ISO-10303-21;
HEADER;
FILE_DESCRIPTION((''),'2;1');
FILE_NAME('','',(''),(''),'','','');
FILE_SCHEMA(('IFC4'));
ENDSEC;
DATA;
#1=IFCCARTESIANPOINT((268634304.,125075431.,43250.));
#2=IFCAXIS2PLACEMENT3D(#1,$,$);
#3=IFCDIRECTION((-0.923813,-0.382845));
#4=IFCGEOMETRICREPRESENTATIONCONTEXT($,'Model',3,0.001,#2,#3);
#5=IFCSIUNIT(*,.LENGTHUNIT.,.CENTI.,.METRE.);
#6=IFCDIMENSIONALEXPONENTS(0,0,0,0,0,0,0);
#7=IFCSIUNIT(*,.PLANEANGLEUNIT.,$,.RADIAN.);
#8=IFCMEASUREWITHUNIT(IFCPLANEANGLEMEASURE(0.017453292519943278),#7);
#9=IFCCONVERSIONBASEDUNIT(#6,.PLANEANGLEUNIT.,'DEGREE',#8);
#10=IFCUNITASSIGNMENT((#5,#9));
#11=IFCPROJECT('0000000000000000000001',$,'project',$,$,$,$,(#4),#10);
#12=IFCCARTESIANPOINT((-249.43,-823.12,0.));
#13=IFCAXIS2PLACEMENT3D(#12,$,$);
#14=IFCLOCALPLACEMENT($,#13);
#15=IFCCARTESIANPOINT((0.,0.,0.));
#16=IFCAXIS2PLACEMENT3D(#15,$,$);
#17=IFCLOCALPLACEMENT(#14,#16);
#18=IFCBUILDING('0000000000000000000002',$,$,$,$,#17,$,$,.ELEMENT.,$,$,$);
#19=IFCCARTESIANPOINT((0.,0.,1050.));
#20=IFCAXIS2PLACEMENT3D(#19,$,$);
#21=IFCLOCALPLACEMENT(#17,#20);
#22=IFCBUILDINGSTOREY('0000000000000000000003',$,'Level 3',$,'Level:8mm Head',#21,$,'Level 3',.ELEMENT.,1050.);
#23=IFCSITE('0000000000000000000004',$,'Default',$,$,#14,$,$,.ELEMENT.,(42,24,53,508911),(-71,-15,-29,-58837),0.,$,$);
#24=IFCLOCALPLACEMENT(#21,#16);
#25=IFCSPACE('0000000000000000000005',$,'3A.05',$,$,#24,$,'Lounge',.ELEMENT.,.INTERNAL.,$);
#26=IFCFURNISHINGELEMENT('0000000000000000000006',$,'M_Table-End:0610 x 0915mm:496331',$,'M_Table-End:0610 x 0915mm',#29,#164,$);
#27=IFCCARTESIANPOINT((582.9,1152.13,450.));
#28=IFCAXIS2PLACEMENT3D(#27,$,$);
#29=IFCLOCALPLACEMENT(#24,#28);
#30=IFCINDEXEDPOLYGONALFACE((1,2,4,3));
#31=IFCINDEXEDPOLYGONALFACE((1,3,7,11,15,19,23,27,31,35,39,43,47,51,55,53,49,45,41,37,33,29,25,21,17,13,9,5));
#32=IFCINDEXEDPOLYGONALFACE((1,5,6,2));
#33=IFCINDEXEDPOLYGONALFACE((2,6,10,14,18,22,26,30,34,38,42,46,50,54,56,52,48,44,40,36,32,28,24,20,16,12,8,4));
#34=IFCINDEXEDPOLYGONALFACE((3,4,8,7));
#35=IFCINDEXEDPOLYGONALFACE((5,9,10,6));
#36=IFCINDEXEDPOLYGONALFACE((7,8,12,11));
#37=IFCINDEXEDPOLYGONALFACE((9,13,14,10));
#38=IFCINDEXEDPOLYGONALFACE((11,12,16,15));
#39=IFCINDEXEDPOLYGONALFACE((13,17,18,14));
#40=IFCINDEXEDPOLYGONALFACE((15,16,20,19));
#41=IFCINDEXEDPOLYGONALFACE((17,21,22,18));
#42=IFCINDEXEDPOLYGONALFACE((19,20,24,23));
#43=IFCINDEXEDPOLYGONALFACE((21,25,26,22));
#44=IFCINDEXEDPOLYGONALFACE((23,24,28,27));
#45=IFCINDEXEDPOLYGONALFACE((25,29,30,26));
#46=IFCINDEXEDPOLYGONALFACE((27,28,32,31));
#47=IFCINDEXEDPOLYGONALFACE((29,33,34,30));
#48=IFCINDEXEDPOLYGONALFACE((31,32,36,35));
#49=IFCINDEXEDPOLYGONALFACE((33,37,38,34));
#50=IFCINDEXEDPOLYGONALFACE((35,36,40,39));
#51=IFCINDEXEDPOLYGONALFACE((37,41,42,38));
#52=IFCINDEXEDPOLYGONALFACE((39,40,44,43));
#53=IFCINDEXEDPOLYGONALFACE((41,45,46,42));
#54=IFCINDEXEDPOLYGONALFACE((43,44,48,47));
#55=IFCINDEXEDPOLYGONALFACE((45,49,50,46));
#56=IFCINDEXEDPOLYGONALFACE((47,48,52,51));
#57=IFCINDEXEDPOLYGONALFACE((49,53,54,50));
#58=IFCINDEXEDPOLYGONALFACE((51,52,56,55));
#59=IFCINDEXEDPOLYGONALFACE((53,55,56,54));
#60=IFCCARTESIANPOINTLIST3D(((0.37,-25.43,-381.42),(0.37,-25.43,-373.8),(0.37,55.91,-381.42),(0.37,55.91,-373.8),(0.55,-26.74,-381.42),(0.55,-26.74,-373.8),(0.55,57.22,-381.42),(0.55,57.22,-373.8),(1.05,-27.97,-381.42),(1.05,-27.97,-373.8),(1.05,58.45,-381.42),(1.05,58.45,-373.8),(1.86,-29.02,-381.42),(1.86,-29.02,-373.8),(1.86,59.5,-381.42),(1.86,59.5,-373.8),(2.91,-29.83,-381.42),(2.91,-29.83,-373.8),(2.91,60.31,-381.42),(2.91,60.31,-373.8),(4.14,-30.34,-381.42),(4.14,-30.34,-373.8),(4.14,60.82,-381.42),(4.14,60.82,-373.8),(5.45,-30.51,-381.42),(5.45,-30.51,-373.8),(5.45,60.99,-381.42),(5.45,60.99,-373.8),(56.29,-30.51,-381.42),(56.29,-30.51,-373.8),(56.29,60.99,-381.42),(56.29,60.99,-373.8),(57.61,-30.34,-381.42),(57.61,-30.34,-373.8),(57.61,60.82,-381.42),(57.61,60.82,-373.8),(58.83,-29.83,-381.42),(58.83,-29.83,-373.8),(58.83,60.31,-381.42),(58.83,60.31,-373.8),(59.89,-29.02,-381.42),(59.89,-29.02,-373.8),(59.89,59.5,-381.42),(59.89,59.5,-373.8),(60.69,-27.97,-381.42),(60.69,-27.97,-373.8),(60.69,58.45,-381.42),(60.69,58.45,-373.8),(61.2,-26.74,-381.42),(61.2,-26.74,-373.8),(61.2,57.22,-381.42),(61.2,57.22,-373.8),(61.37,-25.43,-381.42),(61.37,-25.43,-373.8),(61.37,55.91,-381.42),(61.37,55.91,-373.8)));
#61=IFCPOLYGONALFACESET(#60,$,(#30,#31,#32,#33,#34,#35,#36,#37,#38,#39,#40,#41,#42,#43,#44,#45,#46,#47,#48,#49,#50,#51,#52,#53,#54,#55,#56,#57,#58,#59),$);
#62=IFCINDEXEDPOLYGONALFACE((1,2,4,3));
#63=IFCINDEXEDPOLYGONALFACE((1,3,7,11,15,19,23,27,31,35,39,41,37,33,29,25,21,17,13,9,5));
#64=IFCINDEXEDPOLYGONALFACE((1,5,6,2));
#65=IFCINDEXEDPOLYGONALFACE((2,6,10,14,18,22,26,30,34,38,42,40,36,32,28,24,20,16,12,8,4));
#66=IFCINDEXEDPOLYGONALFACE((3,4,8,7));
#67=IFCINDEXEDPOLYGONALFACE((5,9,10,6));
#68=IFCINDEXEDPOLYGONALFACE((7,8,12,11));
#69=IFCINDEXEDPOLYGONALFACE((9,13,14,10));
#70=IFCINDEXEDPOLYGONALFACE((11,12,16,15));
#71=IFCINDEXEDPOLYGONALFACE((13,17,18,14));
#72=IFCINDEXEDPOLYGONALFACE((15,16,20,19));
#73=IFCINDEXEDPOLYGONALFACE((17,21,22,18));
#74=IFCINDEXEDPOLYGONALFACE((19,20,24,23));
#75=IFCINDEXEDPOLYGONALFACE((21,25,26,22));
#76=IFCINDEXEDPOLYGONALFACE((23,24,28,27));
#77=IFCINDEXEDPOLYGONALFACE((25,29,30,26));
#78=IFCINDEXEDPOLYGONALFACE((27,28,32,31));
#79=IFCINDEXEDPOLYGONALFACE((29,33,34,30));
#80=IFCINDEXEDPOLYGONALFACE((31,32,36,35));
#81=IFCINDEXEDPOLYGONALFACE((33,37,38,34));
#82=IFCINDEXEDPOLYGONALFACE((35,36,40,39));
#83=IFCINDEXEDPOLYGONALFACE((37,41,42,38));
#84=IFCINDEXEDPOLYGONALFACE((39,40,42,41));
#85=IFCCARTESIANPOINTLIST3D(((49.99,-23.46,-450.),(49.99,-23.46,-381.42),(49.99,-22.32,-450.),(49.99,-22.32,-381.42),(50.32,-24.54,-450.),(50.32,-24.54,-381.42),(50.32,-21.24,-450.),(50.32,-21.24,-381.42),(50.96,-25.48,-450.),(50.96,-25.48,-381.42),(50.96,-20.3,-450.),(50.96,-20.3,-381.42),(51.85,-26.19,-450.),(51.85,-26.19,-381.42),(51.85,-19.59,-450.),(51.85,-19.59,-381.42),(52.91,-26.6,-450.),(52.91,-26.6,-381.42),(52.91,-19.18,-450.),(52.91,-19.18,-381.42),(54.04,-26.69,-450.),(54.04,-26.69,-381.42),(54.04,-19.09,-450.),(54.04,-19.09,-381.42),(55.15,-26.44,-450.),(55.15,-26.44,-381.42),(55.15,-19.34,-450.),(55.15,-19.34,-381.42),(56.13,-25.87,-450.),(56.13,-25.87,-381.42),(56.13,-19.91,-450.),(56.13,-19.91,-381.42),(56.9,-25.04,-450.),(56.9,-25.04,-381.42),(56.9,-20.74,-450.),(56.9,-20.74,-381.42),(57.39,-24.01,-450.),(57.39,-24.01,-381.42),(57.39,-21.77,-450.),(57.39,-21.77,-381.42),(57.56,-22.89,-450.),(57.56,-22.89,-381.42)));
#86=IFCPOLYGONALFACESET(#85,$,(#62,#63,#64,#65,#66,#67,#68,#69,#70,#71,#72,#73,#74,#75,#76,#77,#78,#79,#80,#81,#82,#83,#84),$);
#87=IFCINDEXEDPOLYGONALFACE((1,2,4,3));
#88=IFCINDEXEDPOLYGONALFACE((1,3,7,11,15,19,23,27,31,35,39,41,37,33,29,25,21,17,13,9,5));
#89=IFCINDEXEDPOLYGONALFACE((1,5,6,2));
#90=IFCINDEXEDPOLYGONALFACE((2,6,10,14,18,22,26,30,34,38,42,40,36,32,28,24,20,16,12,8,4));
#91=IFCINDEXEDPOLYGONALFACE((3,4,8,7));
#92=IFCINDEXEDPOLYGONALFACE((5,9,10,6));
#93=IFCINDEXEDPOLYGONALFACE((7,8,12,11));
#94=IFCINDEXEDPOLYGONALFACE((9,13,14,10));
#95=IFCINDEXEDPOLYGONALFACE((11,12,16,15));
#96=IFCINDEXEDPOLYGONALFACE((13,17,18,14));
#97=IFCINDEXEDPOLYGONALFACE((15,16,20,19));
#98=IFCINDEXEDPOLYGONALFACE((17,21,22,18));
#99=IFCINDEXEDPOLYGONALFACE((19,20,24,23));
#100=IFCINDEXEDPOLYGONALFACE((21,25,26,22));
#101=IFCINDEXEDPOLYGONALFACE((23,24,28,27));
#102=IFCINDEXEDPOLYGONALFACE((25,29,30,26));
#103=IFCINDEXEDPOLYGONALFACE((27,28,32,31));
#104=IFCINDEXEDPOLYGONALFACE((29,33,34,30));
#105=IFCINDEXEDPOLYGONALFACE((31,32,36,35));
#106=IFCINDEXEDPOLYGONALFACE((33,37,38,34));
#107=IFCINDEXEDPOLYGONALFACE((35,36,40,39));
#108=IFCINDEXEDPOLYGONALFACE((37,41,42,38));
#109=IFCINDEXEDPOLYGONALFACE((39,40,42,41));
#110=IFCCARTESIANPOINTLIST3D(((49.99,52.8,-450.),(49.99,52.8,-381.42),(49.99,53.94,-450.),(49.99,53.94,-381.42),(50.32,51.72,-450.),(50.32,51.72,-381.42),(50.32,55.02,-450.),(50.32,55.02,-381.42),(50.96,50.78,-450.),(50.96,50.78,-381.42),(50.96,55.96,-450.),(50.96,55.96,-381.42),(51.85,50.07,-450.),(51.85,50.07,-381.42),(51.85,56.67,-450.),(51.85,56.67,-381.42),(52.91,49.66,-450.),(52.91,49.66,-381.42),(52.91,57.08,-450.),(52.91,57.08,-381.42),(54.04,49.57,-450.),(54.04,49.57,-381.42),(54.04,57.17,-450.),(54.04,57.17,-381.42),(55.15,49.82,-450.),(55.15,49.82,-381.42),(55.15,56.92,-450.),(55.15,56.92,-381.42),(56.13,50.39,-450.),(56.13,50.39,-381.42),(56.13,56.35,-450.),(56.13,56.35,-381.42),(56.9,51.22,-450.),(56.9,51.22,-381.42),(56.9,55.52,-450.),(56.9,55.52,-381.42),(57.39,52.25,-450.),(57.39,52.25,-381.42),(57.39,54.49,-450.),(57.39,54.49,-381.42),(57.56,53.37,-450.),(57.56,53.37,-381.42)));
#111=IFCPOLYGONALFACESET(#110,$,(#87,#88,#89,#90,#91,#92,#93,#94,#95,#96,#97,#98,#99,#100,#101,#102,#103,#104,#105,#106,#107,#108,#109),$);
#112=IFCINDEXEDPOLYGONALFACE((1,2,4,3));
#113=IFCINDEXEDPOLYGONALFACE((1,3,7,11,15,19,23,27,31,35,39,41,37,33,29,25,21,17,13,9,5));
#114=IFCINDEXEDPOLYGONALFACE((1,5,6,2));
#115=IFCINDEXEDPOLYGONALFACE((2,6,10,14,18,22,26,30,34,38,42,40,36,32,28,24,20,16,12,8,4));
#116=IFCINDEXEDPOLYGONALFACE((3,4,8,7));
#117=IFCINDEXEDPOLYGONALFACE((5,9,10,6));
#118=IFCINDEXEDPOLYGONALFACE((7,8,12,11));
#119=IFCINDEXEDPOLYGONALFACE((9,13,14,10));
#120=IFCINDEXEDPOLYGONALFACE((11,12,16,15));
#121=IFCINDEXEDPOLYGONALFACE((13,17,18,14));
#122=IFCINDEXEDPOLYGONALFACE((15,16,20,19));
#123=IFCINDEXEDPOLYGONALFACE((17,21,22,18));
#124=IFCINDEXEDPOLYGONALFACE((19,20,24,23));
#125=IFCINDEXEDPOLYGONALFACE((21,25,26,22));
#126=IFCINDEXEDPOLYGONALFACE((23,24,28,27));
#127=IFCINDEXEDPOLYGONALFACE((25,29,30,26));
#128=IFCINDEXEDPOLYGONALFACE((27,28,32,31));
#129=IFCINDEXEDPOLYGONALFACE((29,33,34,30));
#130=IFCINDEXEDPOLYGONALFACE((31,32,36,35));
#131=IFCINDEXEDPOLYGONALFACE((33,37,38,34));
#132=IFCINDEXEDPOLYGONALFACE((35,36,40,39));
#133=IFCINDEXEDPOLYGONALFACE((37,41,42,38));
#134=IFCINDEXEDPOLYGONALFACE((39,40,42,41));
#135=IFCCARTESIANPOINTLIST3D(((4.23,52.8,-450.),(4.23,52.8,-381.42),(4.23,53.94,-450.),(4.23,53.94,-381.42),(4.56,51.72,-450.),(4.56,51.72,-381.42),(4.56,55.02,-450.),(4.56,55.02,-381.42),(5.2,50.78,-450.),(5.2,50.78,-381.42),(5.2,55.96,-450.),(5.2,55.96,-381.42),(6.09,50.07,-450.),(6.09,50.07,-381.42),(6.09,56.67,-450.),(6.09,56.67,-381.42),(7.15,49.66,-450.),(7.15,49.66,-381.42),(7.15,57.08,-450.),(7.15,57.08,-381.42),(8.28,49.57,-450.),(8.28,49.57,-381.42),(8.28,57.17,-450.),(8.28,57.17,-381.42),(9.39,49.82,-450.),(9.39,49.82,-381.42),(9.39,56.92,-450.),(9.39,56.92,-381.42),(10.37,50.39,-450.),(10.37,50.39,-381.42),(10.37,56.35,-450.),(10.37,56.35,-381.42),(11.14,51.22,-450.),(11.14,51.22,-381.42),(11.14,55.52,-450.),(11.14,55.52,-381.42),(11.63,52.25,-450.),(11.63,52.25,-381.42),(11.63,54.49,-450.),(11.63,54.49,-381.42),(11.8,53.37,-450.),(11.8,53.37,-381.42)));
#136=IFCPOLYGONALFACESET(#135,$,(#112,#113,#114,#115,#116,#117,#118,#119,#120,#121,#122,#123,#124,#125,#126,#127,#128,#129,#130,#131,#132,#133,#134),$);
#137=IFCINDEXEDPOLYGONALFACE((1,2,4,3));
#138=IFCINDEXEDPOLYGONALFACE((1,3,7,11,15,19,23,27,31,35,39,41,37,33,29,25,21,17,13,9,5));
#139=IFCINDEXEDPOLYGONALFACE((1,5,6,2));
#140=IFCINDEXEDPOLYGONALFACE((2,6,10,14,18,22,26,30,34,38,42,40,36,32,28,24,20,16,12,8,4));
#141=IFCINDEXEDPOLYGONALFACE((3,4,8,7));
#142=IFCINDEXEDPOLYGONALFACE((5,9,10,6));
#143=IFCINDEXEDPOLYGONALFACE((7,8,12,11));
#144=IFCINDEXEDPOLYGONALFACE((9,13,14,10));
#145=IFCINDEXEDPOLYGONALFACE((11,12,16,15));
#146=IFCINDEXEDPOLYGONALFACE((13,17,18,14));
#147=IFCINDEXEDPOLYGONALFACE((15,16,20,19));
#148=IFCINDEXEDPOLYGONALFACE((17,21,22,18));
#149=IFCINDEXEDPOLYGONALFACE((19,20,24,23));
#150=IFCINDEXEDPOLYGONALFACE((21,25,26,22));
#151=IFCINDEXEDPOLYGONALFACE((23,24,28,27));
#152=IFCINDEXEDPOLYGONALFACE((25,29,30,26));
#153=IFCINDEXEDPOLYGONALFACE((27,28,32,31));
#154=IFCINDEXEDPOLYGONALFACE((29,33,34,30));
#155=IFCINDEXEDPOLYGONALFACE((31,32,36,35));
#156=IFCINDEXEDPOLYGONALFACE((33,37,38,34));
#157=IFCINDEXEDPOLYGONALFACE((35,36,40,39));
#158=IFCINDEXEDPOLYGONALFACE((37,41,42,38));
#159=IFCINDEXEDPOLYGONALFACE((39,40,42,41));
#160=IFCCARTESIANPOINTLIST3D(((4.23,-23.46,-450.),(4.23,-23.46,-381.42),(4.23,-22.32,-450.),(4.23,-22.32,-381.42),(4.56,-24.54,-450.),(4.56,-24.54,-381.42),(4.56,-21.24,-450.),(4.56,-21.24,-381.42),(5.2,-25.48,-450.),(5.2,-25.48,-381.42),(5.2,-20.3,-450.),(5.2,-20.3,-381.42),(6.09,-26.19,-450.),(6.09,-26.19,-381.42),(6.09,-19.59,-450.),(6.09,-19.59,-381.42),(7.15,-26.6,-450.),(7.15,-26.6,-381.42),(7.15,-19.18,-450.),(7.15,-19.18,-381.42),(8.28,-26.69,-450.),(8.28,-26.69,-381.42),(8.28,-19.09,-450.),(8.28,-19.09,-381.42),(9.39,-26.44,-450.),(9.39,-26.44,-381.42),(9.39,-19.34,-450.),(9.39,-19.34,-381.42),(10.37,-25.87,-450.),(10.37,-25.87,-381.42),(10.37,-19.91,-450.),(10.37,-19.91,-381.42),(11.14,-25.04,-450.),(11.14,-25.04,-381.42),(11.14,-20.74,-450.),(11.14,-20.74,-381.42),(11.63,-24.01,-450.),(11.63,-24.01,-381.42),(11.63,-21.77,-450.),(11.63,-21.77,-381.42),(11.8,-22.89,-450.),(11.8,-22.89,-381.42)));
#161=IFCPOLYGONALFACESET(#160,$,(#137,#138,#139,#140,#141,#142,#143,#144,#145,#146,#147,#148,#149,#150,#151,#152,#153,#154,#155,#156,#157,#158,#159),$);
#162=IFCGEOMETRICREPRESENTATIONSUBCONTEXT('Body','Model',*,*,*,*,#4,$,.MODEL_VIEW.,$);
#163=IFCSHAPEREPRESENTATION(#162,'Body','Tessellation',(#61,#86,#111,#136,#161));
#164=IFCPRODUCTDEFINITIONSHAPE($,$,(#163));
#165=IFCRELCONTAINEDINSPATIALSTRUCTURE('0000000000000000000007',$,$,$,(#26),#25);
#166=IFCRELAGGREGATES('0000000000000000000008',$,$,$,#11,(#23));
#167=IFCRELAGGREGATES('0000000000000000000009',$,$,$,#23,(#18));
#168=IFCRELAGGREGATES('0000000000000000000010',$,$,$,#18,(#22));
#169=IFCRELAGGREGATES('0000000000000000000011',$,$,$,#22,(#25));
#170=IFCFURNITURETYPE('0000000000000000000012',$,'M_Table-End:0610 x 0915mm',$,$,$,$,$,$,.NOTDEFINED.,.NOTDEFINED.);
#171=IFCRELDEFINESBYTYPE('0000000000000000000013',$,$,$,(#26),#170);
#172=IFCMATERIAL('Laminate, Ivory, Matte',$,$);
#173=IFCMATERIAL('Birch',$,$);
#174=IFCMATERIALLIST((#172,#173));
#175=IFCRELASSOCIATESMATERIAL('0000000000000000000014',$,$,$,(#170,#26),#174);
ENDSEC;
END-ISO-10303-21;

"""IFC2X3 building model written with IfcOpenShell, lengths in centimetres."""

from ifc_helpers import new_model, entity, si_unit, converted_unit, direction, frame, frame_2d, origin, place, context, subcontext, project, spatial, polyline, circle_curve, parameter, trimmed, segment, composite_curve, circle, outline, extrude, source, transform, mapped, material, material_list, type_object, type_shapes, element, save


model = new_model("IFC2X3")

# Units and contexts
model_context = context("Model", 3, precision=0.001, world=frame((268634304.0, 125075431.0, 43250.0)), true_north=direction((-0.923813, -0.382845)))
body_context = subcontext(model_context, "Body", "Model", "MODEL_VIEW")
ifc_project = project(units=[si_unit("LENGTHUNIT", "METRE", prefix="CENTI"), converted_unit("PLANEANGLEUNIT", "DEGREE", entity("IfcPlaneAngleMeasure", 0.017453292519943278), si_unit("PLANEANGLEUNIT", "RADIAN"), dimensions=[0, 0, 0, 0, 0, 0, 0])], contexts=[model_context])

# Site, building, storey
site_placement = place(None, frame((-249.43, -823.12, 0.0)))
site = spatial("IfcSite", under=ifc_project, at=site_placement, Name="Default", CompositionType="ELEMENT", RefLatitude=(42, 24, 53, 508911), RefLongitude=(-71, -15, -29, -58837), RefElevation=0.0)
building_placement = place(site_placement, origin())
building = spatial("IfcBuilding", under=site, at=building_placement, CompositionType="ELEMENT")
storey_placement = place(building_placement, frame((0.0, 0.0, 1050.0)))
storey = spatial("IfcBuildingStorey", under=building, at=storey_placement, Name="Level 3", ObjectType="Level:8mm Head", LongName="Level 3", CompositionType="ELEMENT", Elevation=1050.0)

# Shared definitions
space_1_placement = place(storey_placement, origin())
space_1 = spatial("IfcSpace", under=storey, at=space_1_placement, Name="3A.05", LongName="Lounge", CompositionType="ELEMENT", InteriorOrExteriorSpace="INTERNAL")

# Furnishing element
ifc_material_1 = material(Name="Laminate, Ivory, Matte")
ifc_material_2 = material(Name="Birch")
ifc_material_list_1 = material_list([ifc_material_1, ifc_material_2])
furniture_type_1 = type_object("IfcFurnitureType", Name="M_Table-End:0610 x 0915mm", AssemblyPlace="NOTDEFINED", material=ifc_material_list_1)
shared_shape_1 = source(origin(), body_context, "Body", "SweptSolid", [
    extrude(outline(composite_curve([segment(trimmed(circle_curve(frame_2d((25.42, -40.67), x_axis=(1.0, 0.0)), 5.08), [parameter(270.0)], [parameter(0.0)], True, "PARAMETER"), True, "CONTINUOUS"), segment(polyline([(30.5, -40.67), (30.5, 40.67)]), True, "CONTINUOUS"), segment(trimmed(circle_curve(frame_2d((25.42, 40.67), x_axis=(1.0, 0.0)), 5.08), [parameter(360.0)], [parameter(90.0)], True, "PARAMETER"), True, "CONTINUOUS"), segment(polyline([(25.42, 45.75), (-25.42, 45.75)]), True, "CONTINUOUS"), segment(trimmed(circle_curve(frame_2d((-25.42, 40.67), x_axis=(1.0, 0.0)), 5.08), [parameter(90.0)], [parameter(180.0)], True, "PARAMETER"), True, "CONTINUOUS"), segment(polyline([(-30.5, 40.67), (-30.5, -40.67)]), True, "CONTINUOUS"), segment(trimmed(circle_curve(frame_2d((-25.42, -40.67), x_axis=(1.0, 0.0)), 5.08), [parameter(180.0)], [parameter(270.0)], True, "PARAMETER"), True, "CONTINUOUS"), segment(polyline([(-25.42, -45.75), (25.42, -45.75)]), True, "CONTINUOUS")], self_intersect=False)), frame((30.87, 15.24, -381.42)), (0.0, 0.0, 1.0), 7.62),
    extrude(circle(Radius=3.81, at=frame_2d((0.0, 0.0), x_axis=(1.0, 0.0))), frame((53.75, -22.89, -450.0)), (0.0, 0.0, 1.0), 68.58),
    extrude(circle(Radius=3.81, at=frame_2d((0.0, 0.0), x_axis=(1.0, 0.0))), frame((53.75, 53.37, -450.0)), (0.0, 0.0, 1.0), 68.58),
    extrude(circle(Radius=3.81, at=frame_2d((0.0, 0.0), x_axis=(1.0, 0.0))), frame((7.99, 53.37, -450.0)), (0.0, 0.0, 1.0), 68.58),
    extrude(circle(Radius=3.81, at=frame_2d((0.0, 0.0), x_axis=(1.0, 0.0))), frame((7.99, -22.89, -450.0)), (0.0, 0.0, 1.0), 68.58),
])
type_shapes(furniture_type_1, [shared_shape_1])
furnishing_1_placement = place(space_1_placement, frame((582.9, 1152.13, 450.0)))
element("IfcFurnishingElement", 1, at=furnishing_1_placement, inside=space_1, type_object=furniture_type_1, material=ifc_material_list_1, Name="M_Table-End:0610 x 0915mm:496331", ObjectType="M_Table-End:0610 x 0915mm", context=body_context, shape_type="MappedRepresentation", body=[
    mapped(shared_shape_1, transform((0.0, 0.0, 0.0), scale=1.0)),
])

save(model, "model.ifc")
